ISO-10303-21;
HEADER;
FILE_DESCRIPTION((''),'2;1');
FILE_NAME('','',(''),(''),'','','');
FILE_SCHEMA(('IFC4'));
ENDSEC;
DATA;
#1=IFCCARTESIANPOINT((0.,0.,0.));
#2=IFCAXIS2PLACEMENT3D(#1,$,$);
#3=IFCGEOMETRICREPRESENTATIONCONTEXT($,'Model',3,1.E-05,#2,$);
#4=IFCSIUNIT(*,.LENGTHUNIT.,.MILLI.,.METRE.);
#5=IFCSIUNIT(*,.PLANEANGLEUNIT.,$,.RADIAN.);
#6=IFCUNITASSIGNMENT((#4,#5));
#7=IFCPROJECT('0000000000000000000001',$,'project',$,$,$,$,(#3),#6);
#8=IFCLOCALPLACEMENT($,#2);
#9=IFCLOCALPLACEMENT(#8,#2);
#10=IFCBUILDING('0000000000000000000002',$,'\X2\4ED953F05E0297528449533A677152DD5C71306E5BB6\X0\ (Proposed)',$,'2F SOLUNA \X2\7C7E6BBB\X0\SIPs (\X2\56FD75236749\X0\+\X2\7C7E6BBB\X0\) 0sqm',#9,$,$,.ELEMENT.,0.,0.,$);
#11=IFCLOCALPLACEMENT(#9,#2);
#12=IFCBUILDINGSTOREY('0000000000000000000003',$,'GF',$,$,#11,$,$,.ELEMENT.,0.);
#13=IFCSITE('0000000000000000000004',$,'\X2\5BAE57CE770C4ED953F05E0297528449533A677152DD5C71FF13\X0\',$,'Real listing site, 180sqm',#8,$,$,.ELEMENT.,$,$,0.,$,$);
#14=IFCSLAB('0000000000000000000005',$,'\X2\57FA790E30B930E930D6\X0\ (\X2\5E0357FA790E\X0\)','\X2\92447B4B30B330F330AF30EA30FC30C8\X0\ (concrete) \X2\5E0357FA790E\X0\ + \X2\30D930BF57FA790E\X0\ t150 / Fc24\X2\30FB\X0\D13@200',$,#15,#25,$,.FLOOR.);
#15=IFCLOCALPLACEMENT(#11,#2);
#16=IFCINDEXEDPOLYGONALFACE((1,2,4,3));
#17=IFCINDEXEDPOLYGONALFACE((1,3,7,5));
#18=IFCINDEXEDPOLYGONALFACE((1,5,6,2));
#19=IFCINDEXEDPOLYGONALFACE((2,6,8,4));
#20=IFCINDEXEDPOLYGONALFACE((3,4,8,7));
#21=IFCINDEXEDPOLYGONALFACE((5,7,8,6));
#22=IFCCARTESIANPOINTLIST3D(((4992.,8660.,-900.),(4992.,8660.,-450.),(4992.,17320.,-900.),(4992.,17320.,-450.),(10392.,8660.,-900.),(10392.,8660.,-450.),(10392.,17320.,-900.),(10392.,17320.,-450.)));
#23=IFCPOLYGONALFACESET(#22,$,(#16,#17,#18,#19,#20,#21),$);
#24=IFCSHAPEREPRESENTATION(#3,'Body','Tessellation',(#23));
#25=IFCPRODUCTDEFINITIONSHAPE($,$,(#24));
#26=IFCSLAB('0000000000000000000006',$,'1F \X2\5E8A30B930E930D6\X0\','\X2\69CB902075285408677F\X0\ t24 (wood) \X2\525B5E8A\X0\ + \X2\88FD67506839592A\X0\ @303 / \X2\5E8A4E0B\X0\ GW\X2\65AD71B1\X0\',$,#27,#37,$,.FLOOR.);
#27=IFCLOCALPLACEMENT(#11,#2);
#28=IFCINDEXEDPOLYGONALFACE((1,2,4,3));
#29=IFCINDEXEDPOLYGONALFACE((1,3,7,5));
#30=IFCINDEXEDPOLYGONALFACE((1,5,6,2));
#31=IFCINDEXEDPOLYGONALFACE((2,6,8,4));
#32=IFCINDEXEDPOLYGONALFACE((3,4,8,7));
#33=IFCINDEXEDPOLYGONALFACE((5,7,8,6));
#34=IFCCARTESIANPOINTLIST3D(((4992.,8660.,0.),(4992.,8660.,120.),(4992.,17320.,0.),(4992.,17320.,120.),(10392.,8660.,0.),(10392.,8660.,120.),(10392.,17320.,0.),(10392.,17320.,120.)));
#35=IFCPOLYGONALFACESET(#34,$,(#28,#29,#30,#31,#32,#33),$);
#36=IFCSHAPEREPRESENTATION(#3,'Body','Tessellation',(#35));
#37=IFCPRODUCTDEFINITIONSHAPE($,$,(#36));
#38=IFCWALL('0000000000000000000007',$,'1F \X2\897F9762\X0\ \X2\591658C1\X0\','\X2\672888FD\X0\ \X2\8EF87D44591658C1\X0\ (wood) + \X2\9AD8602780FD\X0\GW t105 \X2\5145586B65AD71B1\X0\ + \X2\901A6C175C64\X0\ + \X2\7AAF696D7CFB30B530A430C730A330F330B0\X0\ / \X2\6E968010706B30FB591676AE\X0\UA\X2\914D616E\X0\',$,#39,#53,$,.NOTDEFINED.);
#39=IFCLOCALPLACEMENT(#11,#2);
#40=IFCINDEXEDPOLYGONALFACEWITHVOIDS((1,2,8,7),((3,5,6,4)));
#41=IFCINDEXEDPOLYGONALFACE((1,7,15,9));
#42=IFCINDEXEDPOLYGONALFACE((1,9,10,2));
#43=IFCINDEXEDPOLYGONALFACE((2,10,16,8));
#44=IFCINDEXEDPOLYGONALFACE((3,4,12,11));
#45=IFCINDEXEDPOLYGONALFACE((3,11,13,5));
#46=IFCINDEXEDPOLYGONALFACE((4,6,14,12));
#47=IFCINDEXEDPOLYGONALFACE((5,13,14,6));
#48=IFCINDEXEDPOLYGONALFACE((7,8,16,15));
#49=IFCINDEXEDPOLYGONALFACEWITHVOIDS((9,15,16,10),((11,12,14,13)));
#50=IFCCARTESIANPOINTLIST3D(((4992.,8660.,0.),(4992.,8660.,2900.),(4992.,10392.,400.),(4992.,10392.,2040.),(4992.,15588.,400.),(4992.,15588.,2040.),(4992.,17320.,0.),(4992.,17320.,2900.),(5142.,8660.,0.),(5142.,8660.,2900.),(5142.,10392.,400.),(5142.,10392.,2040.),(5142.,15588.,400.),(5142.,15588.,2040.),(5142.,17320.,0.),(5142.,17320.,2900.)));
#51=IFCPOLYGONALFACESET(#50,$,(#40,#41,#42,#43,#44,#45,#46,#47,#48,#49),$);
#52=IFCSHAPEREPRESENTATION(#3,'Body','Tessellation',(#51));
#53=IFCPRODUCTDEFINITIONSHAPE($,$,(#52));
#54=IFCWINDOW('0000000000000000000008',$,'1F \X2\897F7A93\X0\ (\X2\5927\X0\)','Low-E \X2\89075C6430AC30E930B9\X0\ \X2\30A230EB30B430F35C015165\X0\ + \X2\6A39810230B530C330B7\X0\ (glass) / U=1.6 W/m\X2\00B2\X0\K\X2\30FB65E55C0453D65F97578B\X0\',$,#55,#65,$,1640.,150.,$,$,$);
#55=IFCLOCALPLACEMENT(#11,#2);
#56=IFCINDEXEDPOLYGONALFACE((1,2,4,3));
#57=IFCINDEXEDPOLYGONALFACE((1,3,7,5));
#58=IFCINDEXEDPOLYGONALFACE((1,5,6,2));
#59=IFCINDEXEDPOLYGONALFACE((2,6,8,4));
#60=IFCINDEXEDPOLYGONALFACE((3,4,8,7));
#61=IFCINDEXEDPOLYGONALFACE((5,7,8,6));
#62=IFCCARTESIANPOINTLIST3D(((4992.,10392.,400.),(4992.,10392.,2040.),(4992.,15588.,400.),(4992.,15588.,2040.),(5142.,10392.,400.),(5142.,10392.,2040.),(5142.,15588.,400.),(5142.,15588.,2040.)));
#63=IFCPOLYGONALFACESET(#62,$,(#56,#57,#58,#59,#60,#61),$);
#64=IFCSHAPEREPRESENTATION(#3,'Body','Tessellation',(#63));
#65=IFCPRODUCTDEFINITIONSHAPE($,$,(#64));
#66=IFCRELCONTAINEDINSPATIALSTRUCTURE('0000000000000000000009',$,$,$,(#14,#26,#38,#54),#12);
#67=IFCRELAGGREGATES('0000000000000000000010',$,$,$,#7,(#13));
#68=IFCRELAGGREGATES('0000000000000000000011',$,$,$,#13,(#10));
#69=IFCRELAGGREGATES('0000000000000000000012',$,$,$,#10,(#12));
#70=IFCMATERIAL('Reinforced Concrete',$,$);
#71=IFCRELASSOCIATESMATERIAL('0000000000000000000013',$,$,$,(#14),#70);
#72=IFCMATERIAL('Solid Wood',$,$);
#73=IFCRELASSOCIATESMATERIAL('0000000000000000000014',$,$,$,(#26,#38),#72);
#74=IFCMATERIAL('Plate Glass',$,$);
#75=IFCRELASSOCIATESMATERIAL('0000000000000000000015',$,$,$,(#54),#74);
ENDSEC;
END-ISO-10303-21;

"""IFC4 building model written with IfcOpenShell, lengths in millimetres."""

from ifc_helpers import new_model, si_unit, frame, frame_2d, origin, place, context, project, spatial, rectangle, extrude, material, element, fill, save


model = new_model("IFC4")

# Units and contexts
model_context = context("Model", 3, precision=1e-05, world=origin())
ifc_project = project(units=[si_unit("LENGTHUNIT", "METRE", prefix="MILLI"), si_unit("PLANEANGLEUNIT", "RADIAN")], contexts=[model_context])

# Site, building, storey
site_placement = place(None, origin())
site = spatial("IfcSite", under=ifc_project, at=site_placement, Name="宮城県仙台市青葉区東勝山３", ObjectType="Real listing site, 180sqm", CompositionType="ELEMENT", RefElevation=0.0)
building_placement = place(site_placement, origin())
building = spatial("IfcBuilding", under=site, at=building_placement, Name="仙台市青葉区東勝山の家 (Proposed)", ObjectType="2F SOLUNA 籾殻SIPs (国産杉+籾殻) 0sqm", CompositionType="ELEMENT", ElevationOfRefHeight=0.0, ElevationOfTerrain=0.0)
storey_placement = place(building_placement, origin())
storey = spatial("IfcBuildingStorey", under=building, at=storey_placement, Name="GF", CompositionType="ELEMENT", Elevation=0.0)

# Slabs
ifc_material_1 = material(Name="Reinforced Concrete")
slab_1_placement = place(storey_placement, frame((2496.0, 4330.0, -450.0)))
element("IfcSlab", 1, at=slab_1_placement, inside=storey, material=ifc_material_1, Name="基礎スラブ (布基礎)", Description="鉄筋コンクリート (concrete) 布基礎 + ベタ基礎 t150 / Fc24・D13@200", PredefinedType="FLOOR", context=model_context, shape_type="SweptSolid", body=[
    extrude(rectangle(XDim=5400.0, YDim=8660.0, at=frame_2d((2700.0, 4330.0))), frame((2496.0, 4330.0, -450.0)), (0.0, 0.0, 1.0), 450.0),
])
ifc_material_2 = material(Name="Solid Wood")
slab_2_placement = place(storey_placement, frame((2496.0, 4330.0, 0.0)))
element("IfcSlab", 2, at=slab_2_placement, inside=storey, material=ifc_material_2, Name="1F 床スラブ", Description="構造用合板 t24 (wood) 剛床 + 製材根太 @303 / 床下 GW断熱", PredefinedType="FLOOR", context=model_context, shape_type="SweptSolid", body=[
    extrude(rectangle(XDim=5400.0, YDim=8660.0, at=frame_2d((2700.0, 4330.0))), frame((2496.0, 4330.0, 0.0)), (0.0, 0.0, 1.0), 120.0),
])

# Shared definitions
ifc_material_3 = material(Name="Plate Glass")

# Wall, opening, window
wall_1_placement = place(storey_placement, frame((2496.0, 4330.0, 0.0)))
wall_1 = element("IfcWall", 3, at=wall_1_placement, inside=storey, material=ifc_material_2, Name="1F 西面 外壁", Description="木製 軸組外壁 (wood) + 高性能GW t105 充填断熱 + 通気層 + 窯業系サイディング / 準耐火・外皮UA配慮", PredefinedType="NOTDEFINED", context=model_context, shape_type="SweptSolid", body=[
    extrude(rectangle(XDim=150.0, YDim=8660.0, at=frame_2d((75.0, 4330.0))), frame((2496.0, 4330.0, 0.0)), (0.0, 0.0, 1.0), 2900.0),
])
opening_1_placement = place(storey_placement, frame((2496.0, 5196.0, 200.0)))
opening_1 = element("IfcOpeningElement", 4, at=opening_1_placement, cuts=wall_1, PredefinedType="NOTDEFINED", context=model_context, shape_type="SweptSolid", body=[
    extrude(rectangle(XDim=150.0, YDim=5196.0, at=frame_2d((75.0, 2598.0))), frame((2496.0, 5196.0, 200.0)), (0.0, 0.0, 1.0), 1640.0),
])
window_1_placement = place(storey_placement, frame((2496.0, 5196.0, 200.0)))
window_1 = element("IfcWindow", 5, at=window_1_placement, inside=storey, material=ifc_material_3, Name="1F 西窓 (大)", Description="Low-E 複層ガラス アルゴン封入 + 樹脂サッシ (glass) / U=1.6 W/m²K・日射取得型", OverallHeight=1640.0, OverallWidth=150.0, context=model_context, shape_type="SweptSolid", body=[
    extrude(rectangle(XDim=150.0, YDim=5196.0, at=frame_2d((75.0, 2598.0))), frame((2496.0, 5196.0, 200.0)), (0.0, 0.0, 1.0), 1640.0),
])
fill(opening_1, window_1)

save(model, "model.ifc")
